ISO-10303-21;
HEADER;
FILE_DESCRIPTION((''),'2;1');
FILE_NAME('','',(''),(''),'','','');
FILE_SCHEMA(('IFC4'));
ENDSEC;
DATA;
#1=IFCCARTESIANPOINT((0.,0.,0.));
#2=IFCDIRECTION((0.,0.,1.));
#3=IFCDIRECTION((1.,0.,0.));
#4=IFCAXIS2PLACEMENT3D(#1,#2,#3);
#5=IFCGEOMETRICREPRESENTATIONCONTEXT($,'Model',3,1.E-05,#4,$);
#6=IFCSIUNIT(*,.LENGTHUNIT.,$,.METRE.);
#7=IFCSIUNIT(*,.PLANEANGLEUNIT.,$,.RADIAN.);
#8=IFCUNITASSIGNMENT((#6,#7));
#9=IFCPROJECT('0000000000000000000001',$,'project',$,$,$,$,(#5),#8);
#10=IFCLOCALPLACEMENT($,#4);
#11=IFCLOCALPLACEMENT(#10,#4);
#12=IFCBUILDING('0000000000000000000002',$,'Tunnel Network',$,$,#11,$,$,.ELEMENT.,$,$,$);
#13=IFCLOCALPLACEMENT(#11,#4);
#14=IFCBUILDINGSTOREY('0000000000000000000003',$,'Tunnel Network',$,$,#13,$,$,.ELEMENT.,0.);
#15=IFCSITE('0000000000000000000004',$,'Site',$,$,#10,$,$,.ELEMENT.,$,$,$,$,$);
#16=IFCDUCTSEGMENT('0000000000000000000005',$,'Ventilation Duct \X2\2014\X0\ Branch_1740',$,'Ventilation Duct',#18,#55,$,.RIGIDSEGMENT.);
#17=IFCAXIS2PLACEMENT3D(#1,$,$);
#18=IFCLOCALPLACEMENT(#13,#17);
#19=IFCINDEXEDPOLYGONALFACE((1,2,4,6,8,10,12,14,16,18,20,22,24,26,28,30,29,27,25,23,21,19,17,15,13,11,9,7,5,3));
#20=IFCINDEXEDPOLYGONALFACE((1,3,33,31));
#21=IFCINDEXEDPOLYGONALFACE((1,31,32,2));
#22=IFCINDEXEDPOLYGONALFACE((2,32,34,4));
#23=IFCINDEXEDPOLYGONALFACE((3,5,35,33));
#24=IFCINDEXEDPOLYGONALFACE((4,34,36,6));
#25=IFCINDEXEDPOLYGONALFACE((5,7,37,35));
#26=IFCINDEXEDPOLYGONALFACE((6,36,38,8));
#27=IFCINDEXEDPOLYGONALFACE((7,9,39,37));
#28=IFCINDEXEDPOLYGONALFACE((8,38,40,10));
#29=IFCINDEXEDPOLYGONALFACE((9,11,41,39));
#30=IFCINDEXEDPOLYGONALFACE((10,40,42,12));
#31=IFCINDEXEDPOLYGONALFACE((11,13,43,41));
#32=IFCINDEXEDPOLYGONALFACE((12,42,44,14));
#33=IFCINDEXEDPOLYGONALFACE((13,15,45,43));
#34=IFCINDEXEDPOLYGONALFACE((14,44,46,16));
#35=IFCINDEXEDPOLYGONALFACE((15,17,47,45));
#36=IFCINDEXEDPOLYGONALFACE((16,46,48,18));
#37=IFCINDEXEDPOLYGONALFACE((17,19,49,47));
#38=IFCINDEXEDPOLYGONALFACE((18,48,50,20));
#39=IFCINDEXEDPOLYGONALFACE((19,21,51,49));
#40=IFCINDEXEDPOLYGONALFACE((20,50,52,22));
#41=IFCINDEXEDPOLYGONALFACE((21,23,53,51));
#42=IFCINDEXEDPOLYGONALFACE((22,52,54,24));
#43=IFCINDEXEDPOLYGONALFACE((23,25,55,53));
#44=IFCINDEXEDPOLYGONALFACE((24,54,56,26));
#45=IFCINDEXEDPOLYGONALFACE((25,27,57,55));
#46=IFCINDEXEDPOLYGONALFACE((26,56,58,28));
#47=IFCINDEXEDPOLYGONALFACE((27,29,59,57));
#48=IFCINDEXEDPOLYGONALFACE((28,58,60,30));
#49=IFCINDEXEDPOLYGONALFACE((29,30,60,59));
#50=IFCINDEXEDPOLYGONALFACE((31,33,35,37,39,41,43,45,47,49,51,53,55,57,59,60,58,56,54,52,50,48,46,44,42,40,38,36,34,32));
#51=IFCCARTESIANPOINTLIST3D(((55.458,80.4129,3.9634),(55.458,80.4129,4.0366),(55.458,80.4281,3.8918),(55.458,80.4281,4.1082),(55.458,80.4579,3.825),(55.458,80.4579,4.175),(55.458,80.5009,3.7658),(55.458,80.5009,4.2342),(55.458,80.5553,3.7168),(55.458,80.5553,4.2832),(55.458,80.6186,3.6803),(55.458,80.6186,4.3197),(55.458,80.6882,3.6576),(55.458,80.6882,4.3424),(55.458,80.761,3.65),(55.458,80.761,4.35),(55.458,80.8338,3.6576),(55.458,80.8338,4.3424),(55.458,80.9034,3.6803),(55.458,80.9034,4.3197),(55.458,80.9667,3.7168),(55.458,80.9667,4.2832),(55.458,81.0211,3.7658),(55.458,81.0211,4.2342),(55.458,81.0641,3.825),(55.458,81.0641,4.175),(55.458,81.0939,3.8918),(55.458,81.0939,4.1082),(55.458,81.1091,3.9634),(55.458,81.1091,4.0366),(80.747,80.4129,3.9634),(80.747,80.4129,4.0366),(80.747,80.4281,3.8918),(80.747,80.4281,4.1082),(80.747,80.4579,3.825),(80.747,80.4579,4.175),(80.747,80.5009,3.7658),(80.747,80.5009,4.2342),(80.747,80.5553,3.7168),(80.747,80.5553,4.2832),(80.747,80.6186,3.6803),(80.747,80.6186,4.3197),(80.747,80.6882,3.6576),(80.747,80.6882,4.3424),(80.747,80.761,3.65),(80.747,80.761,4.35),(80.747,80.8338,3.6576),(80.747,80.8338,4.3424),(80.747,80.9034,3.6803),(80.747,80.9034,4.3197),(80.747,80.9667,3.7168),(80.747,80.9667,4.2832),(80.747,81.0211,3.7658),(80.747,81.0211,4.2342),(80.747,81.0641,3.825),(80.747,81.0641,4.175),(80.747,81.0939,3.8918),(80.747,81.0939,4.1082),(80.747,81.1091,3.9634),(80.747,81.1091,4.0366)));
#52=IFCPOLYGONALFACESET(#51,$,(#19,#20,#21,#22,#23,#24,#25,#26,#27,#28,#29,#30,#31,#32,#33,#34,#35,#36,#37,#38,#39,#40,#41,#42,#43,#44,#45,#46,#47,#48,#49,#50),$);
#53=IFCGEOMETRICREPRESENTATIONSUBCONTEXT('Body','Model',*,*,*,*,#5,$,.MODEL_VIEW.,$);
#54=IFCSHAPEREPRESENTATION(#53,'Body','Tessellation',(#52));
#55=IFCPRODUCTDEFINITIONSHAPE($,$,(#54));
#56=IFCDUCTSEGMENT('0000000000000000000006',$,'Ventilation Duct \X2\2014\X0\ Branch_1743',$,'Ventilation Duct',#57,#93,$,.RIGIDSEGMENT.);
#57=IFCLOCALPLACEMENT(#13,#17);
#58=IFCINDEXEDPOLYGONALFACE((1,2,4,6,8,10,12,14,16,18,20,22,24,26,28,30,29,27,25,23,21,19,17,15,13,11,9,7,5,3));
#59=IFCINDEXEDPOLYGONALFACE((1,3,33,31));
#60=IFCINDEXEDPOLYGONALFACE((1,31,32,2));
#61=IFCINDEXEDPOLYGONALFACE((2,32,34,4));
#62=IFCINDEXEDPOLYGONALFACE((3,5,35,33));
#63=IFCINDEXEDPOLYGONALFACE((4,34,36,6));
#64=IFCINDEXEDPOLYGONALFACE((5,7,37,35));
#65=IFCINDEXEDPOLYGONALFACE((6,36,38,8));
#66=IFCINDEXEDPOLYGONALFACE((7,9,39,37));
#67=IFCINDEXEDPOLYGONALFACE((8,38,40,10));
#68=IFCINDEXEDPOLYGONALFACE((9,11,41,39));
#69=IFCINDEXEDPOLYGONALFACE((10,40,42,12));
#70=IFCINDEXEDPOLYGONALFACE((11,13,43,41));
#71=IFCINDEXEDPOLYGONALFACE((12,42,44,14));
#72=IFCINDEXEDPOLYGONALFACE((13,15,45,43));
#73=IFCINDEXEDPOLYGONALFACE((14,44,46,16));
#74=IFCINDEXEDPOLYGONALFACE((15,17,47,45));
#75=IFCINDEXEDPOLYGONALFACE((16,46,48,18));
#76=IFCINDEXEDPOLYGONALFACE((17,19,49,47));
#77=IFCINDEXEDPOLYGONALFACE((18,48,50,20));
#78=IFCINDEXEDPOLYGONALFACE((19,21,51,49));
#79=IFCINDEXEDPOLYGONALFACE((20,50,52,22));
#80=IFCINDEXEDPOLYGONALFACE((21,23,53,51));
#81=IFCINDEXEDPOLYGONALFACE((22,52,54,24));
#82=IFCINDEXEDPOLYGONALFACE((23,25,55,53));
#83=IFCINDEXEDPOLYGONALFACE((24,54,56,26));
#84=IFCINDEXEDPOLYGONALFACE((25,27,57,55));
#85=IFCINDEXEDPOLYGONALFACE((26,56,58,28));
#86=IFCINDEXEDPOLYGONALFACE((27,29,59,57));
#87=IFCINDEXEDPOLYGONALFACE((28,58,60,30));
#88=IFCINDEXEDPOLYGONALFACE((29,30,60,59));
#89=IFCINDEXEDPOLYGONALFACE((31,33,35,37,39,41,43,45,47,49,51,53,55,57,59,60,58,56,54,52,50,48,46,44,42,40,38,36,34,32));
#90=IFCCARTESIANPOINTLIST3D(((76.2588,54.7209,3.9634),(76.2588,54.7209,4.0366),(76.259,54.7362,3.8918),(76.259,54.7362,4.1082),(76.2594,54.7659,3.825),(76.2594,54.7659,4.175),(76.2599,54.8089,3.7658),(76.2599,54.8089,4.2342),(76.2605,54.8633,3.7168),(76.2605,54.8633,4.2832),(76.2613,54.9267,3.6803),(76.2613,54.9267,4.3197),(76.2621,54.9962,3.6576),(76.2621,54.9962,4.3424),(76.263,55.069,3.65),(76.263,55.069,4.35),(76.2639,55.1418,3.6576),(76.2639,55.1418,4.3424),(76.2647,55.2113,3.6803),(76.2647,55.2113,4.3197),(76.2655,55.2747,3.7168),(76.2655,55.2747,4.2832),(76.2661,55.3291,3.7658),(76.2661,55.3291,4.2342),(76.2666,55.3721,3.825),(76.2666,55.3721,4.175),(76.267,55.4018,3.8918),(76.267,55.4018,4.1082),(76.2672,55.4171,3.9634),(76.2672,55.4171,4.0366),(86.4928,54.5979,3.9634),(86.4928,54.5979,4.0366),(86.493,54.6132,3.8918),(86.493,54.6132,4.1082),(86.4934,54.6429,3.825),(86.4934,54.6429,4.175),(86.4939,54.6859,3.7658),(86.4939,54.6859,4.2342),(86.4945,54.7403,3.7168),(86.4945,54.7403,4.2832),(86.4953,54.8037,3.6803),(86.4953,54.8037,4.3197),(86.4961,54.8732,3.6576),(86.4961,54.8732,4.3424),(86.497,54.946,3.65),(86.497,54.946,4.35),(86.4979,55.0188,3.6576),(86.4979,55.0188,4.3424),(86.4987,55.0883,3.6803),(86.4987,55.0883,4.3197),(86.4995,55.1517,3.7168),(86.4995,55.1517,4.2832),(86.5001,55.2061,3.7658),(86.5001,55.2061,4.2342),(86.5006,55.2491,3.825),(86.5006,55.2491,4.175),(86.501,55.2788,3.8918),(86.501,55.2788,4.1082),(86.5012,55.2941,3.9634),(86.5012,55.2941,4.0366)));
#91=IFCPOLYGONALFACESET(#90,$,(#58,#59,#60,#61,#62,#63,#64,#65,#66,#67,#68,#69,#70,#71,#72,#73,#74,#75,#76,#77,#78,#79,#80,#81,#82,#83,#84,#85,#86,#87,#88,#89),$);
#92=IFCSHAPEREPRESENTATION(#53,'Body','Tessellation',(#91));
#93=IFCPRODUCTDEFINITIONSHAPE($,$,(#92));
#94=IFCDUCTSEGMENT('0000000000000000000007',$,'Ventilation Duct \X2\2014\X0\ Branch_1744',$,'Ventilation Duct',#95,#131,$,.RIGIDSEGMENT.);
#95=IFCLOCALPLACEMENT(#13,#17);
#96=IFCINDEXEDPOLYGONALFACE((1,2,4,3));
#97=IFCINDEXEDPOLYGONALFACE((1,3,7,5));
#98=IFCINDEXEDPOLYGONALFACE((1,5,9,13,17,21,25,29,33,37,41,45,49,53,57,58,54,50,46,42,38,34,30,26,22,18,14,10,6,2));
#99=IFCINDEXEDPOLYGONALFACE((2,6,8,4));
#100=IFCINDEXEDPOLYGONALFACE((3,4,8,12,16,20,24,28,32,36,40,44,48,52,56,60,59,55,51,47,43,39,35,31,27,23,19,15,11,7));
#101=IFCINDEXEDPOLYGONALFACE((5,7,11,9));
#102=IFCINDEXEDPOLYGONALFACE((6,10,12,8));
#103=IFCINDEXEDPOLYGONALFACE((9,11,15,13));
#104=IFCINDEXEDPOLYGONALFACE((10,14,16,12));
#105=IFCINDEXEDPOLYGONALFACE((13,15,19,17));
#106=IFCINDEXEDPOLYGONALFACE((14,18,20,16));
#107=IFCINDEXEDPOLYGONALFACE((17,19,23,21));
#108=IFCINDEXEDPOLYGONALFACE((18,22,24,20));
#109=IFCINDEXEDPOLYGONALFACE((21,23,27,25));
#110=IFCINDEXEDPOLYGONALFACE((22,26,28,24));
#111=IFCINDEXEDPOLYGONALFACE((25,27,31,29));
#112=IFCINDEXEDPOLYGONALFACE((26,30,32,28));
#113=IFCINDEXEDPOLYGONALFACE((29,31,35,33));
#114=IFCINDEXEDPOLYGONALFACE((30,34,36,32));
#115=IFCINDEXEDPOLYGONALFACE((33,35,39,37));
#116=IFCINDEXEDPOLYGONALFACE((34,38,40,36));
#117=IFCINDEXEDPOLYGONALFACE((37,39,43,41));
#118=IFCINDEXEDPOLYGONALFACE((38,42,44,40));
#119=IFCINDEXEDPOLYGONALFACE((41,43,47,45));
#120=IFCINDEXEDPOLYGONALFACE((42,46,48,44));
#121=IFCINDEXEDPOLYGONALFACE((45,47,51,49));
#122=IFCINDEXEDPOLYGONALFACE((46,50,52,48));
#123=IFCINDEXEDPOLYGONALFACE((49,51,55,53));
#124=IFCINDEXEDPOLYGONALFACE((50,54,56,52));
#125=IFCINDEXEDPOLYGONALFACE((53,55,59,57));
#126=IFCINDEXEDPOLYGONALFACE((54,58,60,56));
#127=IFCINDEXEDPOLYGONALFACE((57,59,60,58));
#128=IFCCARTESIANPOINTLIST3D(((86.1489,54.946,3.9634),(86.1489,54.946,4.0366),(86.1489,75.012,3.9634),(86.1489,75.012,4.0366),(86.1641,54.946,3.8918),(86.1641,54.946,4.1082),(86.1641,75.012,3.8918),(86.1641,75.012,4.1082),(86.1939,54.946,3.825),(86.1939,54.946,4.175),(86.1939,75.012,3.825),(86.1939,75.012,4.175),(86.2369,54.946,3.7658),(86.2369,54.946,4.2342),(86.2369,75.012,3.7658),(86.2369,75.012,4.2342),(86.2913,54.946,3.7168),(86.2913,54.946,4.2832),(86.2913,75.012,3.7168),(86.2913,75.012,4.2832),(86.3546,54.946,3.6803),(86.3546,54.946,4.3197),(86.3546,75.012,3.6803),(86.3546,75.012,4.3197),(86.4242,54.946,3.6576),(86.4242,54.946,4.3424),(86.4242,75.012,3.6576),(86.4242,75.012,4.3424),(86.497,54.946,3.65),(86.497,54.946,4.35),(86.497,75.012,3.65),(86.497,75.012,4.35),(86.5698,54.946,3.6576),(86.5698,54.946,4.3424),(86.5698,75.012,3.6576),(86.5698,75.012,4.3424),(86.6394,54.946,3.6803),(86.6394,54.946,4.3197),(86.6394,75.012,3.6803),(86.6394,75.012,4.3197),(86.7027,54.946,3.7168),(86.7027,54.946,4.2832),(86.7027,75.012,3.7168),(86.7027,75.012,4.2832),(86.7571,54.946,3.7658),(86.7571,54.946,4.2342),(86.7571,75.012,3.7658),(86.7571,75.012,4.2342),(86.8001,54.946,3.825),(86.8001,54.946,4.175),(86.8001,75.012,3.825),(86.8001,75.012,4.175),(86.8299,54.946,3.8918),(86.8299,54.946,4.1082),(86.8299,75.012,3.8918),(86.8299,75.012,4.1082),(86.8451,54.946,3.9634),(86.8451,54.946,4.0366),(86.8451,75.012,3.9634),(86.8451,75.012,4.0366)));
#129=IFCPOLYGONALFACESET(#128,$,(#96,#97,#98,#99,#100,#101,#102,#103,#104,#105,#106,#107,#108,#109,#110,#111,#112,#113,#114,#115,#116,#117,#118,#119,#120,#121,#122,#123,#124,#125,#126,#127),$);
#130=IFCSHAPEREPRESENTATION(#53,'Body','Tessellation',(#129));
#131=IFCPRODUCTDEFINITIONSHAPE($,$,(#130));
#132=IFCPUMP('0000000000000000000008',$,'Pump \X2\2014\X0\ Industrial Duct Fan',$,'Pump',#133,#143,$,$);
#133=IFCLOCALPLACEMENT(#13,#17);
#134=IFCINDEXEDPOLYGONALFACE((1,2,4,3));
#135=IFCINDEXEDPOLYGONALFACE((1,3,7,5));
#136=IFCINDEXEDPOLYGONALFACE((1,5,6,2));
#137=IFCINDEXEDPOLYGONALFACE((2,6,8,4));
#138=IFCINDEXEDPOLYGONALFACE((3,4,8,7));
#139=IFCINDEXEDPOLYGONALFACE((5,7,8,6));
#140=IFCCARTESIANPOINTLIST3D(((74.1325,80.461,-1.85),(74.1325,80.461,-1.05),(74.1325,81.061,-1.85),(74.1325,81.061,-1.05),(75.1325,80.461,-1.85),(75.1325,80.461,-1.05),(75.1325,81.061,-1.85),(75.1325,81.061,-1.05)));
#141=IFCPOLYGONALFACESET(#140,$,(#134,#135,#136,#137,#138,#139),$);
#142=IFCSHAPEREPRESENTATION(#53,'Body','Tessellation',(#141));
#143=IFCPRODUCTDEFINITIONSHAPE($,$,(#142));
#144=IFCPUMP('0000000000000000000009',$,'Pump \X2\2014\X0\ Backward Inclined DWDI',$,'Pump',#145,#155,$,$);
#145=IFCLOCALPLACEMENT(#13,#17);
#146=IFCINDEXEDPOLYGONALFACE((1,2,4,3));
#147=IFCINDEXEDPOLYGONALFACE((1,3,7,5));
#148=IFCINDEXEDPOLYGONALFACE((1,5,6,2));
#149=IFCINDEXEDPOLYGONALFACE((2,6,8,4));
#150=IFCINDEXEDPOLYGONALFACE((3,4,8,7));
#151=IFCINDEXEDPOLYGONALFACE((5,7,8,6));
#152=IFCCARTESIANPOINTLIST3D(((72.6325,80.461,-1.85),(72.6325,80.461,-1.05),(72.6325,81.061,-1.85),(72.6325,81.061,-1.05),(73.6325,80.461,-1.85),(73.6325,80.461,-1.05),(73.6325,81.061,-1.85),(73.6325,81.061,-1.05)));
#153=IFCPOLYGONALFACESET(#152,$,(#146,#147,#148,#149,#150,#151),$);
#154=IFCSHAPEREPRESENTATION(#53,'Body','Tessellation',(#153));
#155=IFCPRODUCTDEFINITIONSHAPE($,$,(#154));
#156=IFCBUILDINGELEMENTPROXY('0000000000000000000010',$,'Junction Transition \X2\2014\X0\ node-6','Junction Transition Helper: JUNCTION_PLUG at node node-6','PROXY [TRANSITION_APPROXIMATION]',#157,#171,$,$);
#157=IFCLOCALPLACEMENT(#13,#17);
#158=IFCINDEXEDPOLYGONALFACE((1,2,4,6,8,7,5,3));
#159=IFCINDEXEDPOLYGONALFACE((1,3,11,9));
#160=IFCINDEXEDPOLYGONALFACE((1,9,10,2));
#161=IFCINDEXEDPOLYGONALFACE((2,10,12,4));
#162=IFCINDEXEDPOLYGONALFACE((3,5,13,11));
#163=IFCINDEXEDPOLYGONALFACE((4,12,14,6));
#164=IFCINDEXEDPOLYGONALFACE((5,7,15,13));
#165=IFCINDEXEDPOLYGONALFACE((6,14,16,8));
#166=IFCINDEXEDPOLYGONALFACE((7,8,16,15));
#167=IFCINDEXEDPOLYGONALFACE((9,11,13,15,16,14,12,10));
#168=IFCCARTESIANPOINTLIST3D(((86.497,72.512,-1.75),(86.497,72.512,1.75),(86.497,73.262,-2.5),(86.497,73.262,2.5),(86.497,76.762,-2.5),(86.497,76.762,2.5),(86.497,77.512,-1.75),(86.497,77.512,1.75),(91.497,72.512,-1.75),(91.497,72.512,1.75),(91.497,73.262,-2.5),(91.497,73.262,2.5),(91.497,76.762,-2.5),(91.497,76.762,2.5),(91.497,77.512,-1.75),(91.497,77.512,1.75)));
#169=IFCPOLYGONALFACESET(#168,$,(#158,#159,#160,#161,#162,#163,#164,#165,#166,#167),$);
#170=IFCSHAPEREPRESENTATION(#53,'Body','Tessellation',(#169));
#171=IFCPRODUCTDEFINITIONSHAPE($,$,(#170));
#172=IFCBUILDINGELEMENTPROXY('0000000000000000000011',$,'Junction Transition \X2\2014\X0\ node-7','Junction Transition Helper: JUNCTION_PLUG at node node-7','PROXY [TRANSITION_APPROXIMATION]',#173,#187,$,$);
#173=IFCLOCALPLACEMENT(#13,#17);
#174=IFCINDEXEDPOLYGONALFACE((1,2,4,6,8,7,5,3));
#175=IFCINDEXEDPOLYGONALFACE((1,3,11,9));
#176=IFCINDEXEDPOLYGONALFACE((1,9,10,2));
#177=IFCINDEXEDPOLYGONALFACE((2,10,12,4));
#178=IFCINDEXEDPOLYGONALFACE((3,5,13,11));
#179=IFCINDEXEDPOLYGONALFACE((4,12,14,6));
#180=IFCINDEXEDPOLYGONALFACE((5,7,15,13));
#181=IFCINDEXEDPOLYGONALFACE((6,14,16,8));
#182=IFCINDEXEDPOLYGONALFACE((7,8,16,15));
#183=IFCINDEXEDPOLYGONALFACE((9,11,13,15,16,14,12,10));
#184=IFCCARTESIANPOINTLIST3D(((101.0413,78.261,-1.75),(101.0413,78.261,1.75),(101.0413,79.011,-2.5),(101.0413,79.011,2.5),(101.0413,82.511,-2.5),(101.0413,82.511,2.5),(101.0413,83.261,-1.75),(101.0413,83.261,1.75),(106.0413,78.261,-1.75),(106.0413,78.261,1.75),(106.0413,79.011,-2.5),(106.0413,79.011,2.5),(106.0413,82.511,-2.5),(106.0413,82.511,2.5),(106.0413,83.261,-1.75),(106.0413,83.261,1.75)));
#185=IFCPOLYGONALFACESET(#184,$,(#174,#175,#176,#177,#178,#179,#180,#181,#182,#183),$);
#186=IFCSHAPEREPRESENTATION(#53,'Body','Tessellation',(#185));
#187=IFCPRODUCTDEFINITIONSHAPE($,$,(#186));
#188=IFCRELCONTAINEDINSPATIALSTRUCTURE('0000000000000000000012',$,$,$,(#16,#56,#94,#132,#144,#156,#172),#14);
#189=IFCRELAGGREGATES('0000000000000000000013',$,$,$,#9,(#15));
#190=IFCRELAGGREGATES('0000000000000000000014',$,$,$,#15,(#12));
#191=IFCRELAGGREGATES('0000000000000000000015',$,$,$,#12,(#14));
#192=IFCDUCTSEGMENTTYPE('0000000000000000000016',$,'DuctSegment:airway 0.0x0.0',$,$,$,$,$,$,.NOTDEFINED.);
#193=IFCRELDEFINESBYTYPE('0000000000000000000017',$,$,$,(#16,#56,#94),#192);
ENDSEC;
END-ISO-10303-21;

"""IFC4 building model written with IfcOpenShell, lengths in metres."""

from ifc_helpers import new_model, si_unit, frame, origin_with_axes, origin_2d_with_axis, place, context, subcontext, project, spatial, polyline, rectangle, circle, outline, extrude, type_object, element, save


model = new_model("IFC4")

# Units and contexts
model_context = context("Model", 3, precision=1e-05, world=origin_with_axes())
body_context = subcontext(model_context, "Body", "Model", "MODEL_VIEW")
ifc_project = project(units=[si_unit("LENGTHUNIT", "METRE"), si_unit("PLANEANGLEUNIT", "RADIAN")], contexts=[model_context])

# Site, building, storey
site_placement = place(None, origin_with_axes())
site = spatial("IfcSite", under=ifc_project, at=site_placement, Name="Site", CompositionType="ELEMENT")
building_placement = place(site_placement, origin_with_axes())
building = spatial("IfcBuilding", under=site, at=building_placement, Name="Tunnel Network", CompositionType="ELEMENT")
storey_placement = place(building_placement, origin_with_axes())
storey = spatial("IfcBuildingStorey", under=building, at=storey_placement, Name="Tunnel Network", CompositionType="ELEMENT", Elevation=0.0)

# Duct segments
duct_segment_type = type_object("IfcDuctSegmentType", Name="DuctSegment:airway 0.0x0.0")
duct_segment_1_placement = place(storey_placement, frame((80.747, 80.761, 4.0), z_axis=(-1.0, 0.0, 0.0), x_axis=(0.0, 0.0, 1.0)))
element("IfcDuctSegment", 1, at=duct_segment_1_placement, inside=storey, type_object=duct_segment_type, Name="Ventilation Duct — Branch_1740", ObjectType="Ventilation Duct", PredefinedType="RIGIDSEGMENT", context=body_context, shape_type="SweptSolid", body=[
    extrude(circle(Radius=0.35, at=origin_2d_with_axis()), origin_with_axes(), (0.0, 0.0, 1.0), 25.289),
])
duct_segment_2_placement = place(storey_placement, frame((76.263, 55.069, 4.0), z_axis=(0.999928, -0.012018, 0.0), x_axis=(0.0, 0.0, 1.0)))
element("IfcDuctSegment", 2, at=duct_segment_2_placement, inside=storey, type_object=duct_segment_type, Name="Ventilation Duct — Branch_1743", ObjectType="Ventilation Duct", PredefinedType="RIGIDSEGMENT", context=body_context, shape_type="SweptSolid", body=[
    extrude(circle(Radius=0.35, at=origin_2d_with_axis()), origin_with_axes(), (0.0, 0.0, 1.0), 10.2347),
])
duct_segment_3_placement = place(storey_placement, frame((86.497, 54.946, 4.0), z_axis=(0.0, 1.0, 0.0), x_axis=(0.0, 0.0, 1.0)))
element("IfcDuctSegment", 3, at=duct_segment_3_placement, inside=storey, type_object=duct_segment_type, Name="Ventilation Duct — Branch_1744", ObjectType="Ventilation Duct", PredefinedType="RIGIDSEGMENT", context=body_context, shape_type="SweptSolid", body=[
    extrude(circle(Radius=0.35, at=origin_2d_with_axis()), origin_with_axes(), (0.0, 0.0, 1.0), 20.066),
])

# Pumps
for number, where, z_axis, x_axis, name in (
    (4, (74.6325, 80.761, -1.85), (0.0, 0.0, 1.0), (1.0, 0.0, 0.0), "Pump — Industrial Duct Fan"),
    (5, (73.1325, 80.761, -1.85), (0.0, 0.0, 1.0), (1.0, 0.0, 0.0), "Pump — Backward Inclined DWDI"),
):
    element("IfcPump", number, at=place(storey_placement, frame(where, z_axis=z_axis, x_axis=x_axis)), inside=storey, Name=name, ObjectType="Pump", context=body_context, shape_type="SweptSolid", body=[
        extrude(rectangle(XDim=1.0, YDim=0.6, at=origin_2d_with_axis()), origin_with_axes(), (0.0, 0.0, 1.0), 0.8),
    ])

# Building element proxies
for number, where, z_axis, x_axis, name, description in (
    (6, (86.497, 75.012, 0.0), (1.0, 0.0, 0.0), (0.0, -1.0, 0.0), "Junction Transition — node-6", "Junction Transition Helper: JUNCTION_PLUG at node node-6"),
    (7, (106.0413, 80.761, 0.0), (-1.0, 0.0, 0.0), (0.0, 1.0, 0.0), "Junction Transition — node-7", "Junction Transition Helper: JUNCTION_PLUG at node node-7"),
):
    element("IfcBuildingElementProxy", number, at=place(storey_placement, frame(where, z_axis=z_axis, x_axis=x_axis)), inside=storey, Name=name, Description=description, ObjectType="PROXY [TRANSITION_APPROXIMATION]", context=body_context, shape_type="SweptSolid", body=[
        extrude(outline(polyline([(1.75, 2.5), (2.5, 1.75), (2.5, -1.75), (1.75, -2.5), (-1.75, -2.5), (-2.5, -1.75), (-2.5, 1.75), (-1.75, 2.5), (1.75, 2.5)])), origin_with_axes(), (0.0, 0.0, 1.0), 5.0),
    ])

save(model, "model.ifc")
